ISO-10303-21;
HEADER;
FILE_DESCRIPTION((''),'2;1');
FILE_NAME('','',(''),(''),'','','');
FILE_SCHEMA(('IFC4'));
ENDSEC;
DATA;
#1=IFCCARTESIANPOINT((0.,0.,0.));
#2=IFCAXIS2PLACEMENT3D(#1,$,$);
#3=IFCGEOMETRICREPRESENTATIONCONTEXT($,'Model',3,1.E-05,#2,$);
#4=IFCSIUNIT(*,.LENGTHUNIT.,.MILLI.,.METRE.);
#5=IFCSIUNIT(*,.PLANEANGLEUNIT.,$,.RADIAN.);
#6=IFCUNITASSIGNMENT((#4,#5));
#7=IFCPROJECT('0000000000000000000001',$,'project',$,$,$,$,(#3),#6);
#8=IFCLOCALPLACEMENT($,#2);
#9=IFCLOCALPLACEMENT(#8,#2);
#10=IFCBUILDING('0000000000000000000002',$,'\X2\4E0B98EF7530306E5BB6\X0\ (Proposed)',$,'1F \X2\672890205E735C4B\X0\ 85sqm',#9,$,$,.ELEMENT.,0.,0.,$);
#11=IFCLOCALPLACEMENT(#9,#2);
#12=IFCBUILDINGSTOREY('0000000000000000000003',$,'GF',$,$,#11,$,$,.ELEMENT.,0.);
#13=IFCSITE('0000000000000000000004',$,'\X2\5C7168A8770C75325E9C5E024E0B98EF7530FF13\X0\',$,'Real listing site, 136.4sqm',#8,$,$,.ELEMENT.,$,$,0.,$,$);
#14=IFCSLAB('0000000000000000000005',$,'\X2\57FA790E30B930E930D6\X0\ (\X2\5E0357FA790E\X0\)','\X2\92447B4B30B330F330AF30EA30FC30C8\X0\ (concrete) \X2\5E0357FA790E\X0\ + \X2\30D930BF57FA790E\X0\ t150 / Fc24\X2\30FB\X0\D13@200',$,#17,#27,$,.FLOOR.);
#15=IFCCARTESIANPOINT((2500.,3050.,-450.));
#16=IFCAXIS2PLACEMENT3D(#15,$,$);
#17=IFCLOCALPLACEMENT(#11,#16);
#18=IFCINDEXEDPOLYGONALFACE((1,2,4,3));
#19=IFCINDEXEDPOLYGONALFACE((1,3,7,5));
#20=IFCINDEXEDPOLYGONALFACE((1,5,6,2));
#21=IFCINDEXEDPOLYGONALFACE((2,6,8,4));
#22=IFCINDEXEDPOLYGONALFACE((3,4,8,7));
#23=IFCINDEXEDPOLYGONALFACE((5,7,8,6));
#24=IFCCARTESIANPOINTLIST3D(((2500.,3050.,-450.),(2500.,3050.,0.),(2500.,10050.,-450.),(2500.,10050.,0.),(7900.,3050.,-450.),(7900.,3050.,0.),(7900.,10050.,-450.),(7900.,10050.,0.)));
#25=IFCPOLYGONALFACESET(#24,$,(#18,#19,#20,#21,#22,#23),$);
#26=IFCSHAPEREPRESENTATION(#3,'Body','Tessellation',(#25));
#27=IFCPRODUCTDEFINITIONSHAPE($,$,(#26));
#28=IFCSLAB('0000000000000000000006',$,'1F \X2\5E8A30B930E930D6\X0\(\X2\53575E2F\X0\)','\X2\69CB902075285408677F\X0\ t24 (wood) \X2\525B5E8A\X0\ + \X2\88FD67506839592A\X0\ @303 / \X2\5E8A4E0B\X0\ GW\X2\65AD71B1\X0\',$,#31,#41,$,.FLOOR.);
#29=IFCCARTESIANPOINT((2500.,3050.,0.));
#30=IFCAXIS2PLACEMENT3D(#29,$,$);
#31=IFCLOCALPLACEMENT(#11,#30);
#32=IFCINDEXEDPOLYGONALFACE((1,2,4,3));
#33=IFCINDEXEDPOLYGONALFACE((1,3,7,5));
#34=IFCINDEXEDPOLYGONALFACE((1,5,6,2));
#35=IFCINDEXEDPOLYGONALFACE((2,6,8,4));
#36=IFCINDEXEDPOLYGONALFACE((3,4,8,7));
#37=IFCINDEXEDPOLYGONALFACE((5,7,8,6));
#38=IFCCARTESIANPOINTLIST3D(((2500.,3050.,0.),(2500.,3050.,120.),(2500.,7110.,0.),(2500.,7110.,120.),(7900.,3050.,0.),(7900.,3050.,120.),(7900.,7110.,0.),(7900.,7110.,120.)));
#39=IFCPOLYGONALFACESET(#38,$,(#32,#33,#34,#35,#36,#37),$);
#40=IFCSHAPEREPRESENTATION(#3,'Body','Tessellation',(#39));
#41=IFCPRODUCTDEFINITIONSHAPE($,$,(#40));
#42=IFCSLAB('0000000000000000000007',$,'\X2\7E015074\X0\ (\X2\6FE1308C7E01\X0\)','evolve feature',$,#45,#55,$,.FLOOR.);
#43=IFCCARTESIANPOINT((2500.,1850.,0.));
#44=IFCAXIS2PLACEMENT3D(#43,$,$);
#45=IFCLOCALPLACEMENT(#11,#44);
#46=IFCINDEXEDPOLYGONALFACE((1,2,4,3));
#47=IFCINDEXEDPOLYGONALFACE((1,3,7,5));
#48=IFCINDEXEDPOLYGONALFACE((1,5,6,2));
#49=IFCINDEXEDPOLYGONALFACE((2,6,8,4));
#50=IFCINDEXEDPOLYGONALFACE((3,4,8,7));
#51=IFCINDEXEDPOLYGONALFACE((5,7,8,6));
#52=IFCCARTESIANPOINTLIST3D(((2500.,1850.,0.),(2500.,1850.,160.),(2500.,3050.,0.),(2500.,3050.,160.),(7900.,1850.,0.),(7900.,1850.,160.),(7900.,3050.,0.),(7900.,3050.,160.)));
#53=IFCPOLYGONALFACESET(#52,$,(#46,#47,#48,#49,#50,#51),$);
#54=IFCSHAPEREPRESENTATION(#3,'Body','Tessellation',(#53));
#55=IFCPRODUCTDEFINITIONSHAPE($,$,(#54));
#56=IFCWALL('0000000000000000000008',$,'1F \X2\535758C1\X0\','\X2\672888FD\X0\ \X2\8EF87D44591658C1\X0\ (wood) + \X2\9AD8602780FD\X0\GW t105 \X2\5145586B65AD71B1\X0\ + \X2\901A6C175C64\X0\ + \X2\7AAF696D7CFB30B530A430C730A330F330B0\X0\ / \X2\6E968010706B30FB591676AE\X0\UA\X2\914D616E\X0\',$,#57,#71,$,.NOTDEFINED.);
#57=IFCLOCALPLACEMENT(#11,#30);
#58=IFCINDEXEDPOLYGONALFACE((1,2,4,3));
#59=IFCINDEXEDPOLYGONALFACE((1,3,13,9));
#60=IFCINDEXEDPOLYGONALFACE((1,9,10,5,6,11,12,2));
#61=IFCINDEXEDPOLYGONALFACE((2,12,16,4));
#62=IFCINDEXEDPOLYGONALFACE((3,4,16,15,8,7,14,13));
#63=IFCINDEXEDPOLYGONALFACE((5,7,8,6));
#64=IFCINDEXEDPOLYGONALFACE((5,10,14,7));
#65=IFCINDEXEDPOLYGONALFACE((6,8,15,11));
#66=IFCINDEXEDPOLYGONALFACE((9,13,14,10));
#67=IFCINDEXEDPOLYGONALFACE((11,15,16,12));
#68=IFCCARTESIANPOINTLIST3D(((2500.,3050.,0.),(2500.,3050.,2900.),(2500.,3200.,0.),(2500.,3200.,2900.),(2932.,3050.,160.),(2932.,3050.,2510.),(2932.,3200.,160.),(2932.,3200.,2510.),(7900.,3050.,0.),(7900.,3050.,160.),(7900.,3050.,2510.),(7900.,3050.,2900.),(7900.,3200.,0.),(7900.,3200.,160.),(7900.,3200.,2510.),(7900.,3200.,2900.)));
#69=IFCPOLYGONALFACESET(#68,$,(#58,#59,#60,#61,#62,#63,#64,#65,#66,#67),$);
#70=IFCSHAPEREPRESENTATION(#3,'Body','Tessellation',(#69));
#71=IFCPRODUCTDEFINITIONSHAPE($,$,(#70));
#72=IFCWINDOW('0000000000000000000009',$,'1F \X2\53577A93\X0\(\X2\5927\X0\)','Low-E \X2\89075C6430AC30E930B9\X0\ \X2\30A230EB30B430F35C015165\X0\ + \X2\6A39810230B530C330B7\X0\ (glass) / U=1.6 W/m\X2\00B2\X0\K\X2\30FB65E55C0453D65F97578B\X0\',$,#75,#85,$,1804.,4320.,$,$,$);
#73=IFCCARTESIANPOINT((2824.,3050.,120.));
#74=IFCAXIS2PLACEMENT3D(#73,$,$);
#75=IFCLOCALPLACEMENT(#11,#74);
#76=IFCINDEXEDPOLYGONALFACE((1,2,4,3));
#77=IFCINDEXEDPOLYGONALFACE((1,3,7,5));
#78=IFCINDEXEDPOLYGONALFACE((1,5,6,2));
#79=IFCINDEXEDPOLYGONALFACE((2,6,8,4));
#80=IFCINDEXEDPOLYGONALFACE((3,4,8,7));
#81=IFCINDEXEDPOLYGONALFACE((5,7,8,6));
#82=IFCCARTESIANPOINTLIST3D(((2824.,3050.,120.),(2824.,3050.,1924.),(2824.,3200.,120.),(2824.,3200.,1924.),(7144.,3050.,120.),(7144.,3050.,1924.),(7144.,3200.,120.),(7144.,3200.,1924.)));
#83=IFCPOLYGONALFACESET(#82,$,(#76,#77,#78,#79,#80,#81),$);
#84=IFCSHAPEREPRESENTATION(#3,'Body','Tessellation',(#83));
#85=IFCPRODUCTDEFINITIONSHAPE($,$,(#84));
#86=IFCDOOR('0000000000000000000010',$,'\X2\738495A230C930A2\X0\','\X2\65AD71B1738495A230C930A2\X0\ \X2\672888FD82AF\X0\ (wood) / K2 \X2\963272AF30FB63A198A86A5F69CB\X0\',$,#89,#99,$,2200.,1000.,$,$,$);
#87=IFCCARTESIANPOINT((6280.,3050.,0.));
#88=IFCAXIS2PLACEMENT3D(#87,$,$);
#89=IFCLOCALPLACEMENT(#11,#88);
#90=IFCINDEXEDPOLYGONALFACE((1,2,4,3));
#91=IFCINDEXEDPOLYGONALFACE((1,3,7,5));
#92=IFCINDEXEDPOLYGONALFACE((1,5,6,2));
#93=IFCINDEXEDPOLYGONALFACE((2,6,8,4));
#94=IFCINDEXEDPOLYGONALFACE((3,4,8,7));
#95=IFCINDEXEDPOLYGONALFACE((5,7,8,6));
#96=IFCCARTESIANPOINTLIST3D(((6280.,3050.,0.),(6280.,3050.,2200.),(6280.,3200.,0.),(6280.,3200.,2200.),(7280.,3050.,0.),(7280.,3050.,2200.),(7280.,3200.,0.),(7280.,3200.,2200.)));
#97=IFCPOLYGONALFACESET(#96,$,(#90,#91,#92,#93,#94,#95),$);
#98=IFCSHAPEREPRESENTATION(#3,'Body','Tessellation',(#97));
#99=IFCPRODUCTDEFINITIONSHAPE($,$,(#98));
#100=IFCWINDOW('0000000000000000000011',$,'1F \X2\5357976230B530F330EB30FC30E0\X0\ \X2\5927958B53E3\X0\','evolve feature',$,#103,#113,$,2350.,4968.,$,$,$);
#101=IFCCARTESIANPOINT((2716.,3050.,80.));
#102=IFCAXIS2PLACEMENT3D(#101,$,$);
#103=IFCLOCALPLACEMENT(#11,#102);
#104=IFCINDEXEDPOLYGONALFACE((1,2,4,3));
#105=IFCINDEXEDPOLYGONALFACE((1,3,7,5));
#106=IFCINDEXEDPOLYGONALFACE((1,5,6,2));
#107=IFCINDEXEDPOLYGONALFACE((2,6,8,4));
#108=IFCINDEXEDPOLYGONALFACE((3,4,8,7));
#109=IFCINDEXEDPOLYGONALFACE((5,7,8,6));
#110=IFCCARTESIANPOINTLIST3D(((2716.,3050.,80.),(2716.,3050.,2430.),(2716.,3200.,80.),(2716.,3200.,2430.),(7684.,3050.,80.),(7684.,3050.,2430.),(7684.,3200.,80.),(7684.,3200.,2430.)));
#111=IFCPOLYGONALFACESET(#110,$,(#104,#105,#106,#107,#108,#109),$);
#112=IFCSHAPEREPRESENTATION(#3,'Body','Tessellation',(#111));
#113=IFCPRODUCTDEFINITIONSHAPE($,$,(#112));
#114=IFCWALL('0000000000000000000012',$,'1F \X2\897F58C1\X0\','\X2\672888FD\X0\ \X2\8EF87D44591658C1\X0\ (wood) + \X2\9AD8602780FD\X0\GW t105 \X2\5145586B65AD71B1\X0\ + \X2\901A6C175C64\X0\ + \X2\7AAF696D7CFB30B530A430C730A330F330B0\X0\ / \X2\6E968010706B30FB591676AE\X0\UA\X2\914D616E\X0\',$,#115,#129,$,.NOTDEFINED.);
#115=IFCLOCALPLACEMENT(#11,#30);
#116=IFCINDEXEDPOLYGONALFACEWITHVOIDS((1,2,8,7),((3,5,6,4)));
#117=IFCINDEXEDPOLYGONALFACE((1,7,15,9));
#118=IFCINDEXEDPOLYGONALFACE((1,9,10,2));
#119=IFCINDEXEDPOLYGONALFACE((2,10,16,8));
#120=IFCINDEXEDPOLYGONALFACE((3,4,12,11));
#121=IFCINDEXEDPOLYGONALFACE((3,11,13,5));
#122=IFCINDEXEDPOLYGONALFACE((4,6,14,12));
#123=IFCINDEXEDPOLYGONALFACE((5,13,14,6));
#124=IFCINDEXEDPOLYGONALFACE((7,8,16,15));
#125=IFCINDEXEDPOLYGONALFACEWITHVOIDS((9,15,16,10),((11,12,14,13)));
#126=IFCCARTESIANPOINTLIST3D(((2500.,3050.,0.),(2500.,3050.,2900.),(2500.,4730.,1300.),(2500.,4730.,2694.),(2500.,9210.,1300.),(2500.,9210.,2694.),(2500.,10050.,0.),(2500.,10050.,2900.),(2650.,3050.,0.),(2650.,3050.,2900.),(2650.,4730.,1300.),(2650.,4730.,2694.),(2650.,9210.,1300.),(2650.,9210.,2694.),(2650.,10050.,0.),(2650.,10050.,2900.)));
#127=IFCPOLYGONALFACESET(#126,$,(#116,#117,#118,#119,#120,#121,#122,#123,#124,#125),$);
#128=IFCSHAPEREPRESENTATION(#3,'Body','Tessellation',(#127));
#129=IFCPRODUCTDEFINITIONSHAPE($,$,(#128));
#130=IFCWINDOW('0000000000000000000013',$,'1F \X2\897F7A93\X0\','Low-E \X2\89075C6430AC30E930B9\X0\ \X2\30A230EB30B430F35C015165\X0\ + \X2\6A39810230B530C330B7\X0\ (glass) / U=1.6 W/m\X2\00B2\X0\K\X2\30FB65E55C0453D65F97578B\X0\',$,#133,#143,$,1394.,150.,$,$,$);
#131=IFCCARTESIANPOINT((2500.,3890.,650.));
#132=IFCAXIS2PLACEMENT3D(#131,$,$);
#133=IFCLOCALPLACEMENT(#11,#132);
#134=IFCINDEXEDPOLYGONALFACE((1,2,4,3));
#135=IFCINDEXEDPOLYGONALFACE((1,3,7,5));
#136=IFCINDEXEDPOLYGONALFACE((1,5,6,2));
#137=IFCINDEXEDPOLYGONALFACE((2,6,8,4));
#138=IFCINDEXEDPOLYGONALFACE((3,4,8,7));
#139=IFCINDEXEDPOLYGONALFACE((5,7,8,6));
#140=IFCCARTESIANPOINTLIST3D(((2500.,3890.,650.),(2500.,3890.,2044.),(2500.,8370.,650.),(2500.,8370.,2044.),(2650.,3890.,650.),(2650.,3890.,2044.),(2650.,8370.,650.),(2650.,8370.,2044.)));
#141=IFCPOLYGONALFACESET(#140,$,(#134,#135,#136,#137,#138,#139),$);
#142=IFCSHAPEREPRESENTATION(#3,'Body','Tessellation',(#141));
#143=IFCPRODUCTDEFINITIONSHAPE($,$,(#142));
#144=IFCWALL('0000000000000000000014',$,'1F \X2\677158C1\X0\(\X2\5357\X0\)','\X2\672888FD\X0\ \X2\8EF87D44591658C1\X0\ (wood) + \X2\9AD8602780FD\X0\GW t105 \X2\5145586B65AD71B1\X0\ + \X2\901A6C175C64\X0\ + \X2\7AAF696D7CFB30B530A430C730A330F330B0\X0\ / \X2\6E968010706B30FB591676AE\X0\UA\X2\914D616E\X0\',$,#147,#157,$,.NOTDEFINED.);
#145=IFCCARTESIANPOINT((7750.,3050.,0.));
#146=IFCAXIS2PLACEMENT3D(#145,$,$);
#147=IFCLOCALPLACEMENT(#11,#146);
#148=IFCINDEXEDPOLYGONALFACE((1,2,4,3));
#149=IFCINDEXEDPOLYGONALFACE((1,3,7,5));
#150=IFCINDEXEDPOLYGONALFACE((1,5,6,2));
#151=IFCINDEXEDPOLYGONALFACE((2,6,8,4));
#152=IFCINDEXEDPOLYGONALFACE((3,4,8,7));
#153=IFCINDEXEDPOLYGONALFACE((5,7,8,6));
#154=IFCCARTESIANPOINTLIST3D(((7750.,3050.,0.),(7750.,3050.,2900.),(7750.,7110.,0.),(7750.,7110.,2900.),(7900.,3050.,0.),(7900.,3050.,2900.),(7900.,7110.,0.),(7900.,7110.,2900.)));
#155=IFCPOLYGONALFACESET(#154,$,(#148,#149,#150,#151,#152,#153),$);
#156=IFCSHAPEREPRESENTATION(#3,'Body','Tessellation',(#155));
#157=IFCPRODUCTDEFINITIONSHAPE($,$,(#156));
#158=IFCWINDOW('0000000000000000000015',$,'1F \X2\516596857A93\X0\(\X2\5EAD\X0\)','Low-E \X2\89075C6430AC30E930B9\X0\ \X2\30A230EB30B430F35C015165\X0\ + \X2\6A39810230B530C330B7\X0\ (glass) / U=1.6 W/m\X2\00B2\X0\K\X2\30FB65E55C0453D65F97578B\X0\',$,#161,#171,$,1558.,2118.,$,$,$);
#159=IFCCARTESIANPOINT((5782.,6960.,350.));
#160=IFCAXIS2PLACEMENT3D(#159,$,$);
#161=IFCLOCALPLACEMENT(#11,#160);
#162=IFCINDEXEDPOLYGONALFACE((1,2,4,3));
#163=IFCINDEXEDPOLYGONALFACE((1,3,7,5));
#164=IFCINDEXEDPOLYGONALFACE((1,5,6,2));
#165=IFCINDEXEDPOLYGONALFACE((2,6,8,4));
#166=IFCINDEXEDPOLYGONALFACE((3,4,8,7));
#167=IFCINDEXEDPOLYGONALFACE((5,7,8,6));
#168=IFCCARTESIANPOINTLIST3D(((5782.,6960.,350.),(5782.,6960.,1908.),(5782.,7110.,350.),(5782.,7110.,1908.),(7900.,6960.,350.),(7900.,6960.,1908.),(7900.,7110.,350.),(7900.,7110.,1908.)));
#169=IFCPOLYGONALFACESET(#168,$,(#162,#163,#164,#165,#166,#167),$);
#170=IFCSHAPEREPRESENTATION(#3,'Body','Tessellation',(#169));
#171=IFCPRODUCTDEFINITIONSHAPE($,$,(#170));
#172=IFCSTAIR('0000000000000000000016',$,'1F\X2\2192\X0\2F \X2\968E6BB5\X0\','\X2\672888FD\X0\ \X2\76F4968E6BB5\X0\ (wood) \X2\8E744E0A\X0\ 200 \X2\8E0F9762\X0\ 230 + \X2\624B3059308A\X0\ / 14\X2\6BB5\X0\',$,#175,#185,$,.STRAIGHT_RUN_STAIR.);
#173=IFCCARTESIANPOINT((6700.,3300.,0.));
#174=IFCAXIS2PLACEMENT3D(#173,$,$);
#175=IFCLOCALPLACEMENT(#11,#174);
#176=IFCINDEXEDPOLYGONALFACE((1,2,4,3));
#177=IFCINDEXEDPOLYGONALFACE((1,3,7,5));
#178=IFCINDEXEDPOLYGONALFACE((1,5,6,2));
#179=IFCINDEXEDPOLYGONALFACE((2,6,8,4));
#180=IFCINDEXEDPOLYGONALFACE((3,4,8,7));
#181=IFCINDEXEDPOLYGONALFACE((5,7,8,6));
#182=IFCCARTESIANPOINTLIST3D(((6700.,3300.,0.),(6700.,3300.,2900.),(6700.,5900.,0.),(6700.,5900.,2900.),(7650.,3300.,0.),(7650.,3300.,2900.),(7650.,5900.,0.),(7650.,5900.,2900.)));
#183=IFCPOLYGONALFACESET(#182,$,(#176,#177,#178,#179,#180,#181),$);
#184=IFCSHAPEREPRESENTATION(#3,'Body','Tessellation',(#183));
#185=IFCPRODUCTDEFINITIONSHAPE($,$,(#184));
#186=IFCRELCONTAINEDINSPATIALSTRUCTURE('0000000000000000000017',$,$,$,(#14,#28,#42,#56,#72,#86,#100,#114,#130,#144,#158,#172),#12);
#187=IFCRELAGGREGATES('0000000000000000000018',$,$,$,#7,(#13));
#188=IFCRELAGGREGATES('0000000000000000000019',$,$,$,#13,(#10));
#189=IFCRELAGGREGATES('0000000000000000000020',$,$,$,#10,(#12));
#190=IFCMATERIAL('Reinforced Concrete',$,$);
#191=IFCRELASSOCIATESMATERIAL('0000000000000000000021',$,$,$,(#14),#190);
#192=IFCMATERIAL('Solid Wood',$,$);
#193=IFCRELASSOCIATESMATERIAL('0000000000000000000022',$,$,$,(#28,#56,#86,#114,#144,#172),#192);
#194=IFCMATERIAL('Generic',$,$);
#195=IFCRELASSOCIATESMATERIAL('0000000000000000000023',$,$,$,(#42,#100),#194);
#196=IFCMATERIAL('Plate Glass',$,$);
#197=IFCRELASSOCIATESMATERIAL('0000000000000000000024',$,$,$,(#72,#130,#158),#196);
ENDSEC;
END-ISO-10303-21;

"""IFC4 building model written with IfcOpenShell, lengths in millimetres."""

from ifc_helpers import new_model, si_unit, frame, frame_2d, origin, place, context, project, spatial, rectangle, extrude, material, element, fill, save


model = new_model("IFC4")

# Units and contexts
model_context = context("Model", 3, precision=1e-05, world=origin())
ifc_project = project(units=[si_unit("LENGTHUNIT", "METRE", prefix="MILLI"), si_unit("PLANEANGLEUNIT", "RADIAN")], contexts=[model_context])

# Site, building, storey
site_placement = place(None, origin())
site = spatial("IfcSite", under=ifc_project, at=site_placement, Name="山梨県甲府市下飯田３", ObjectType="Real listing site, 136.4sqm", CompositionType="ELEMENT", RefElevation=0.0)
building_placement = place(site_placement, origin())
building = spatial("IfcBuilding", under=site, at=building_placement, Name="下飯田の家 (Proposed)", ObjectType="1F 木造平屋 85sqm", CompositionType="ELEMENT", ElevationOfRefHeight=0.0, ElevationOfTerrain=0.0)
storey_placement = place(building_placement, origin())
storey = spatial("IfcBuildingStorey", under=building, at=storey_placement, Name="GF", CompositionType="ELEMENT", Elevation=0.0)

# Slabs
ifc_material_1 = material(Name="Reinforced Concrete")
slab_1_placement = place(storey_placement, frame((2500.0, 3050.0, -450.0)))
element("IfcSlab", 1, at=slab_1_placement, inside=storey, material=ifc_material_1, Name="基礎スラブ (布基礎)", Description="鉄筋コンクリート (concrete) 布基礎 + ベタ基礎 t150 / Fc24・D13@200", PredefinedType="FLOOR", context=model_context, shape_type="SweptSolid", body=[
    extrude(rectangle(XDim=5400.0, YDim=7000.0, at=frame_2d((2700.0, 3500.0))), frame((2500.0, 3050.0, -450.0)), (0.0, 0.0, 1.0), 450.0),
])
ifc_material_2 = material(Name="Solid Wood")
slab_2_placement = place(storey_placement, frame((2500.0, 3050.0, 0.0)))
element("IfcSlab", 2, at=slab_2_placement, inside=storey, material=ifc_material_2, Name="1F 床スラブ(南帯)", Description="構造用合板 t24 (wood) 剛床 + 製材根太 @303 / 床下 GW断熱", PredefinedType="FLOOR", context=model_context, shape_type="SweptSolid", body=[
    extrude(rectangle(XDim=5400.0, YDim=4060.0, at=frame_2d((2700.0, 2030.0))), frame((2500.0, 3050.0, 0.0)), (0.0, 0.0, 1.0), 120.0),
])
ifc_material_3 = material(Name="Generic")
slab_3_placement = place(storey_placement, frame((2500.0, 1850.0, 0.0)))
element("IfcSlab", 3, at=slab_3_placement, inside=storey, material=ifc_material_3, Name="縁側 (濡れ縁)", Description="evolve feature", PredefinedType="FLOOR", context=model_context, shape_type="SweptSolid", body=[
    extrude(rectangle(XDim=5400.0, YDim=1200.0, at=frame_2d((2700.0, 600.0))), frame((2500.0, 1850.0, 0.0)), (0.0, 0.0, 1.0), 160.0),
])

# Wall, openings, windows, door
wall_1_placement = place(storey_placement, frame((2500.0, 3050.0, 0.0)))
wall_1 = element("IfcWall", 4, at=wall_1_placement, inside=storey, material=ifc_material_2, Name="1F 南壁", Description="木製 軸組外壁 (wood) + 高性能GW t105 充填断熱 + 通気層 + 窯業系サイディング / 準耐火・外皮UA配慮", PredefinedType="NOTDEFINED", context=model_context, shape_type="SweptSolid", body=[
    extrude(rectangle(XDim=5400.0, YDim=150.0, at=frame_2d((2700.0, 75.0))), frame((2500.0, 3050.0, 0.0)), (0.0, 0.0, 1.0), 2900.0),
])
opening_1_placement = place(storey_placement, frame((2824.0, 3050.0, 120.0)))
opening_1 = element("IfcOpeningElement", 5, at=opening_1_placement, cuts=wall_1, PredefinedType="NOTDEFINED", context=model_context, shape_type="SweptSolid", body=[
    extrude(rectangle(XDim=4320.0, YDim=150.0, at=frame_2d((2160.0, 75.0))), frame((2824.0, 3050.0, 120.0)), (0.0, 0.0, 1.0), 1804.0),
])
opening_2_placement = place(storey_placement, frame((6280.0, 3050.0, 0.0)))
opening_2 = element("IfcOpeningElement", 6, at=opening_2_placement, cuts=wall_1, PredefinedType="NOTDEFINED", context=model_context, shape_type="SweptSolid", body=[
    extrude(rectangle(XDim=1000.0, YDim=150.0, at=frame_2d((500.0, 75.0))), frame((6280.0, 3050.0, 0.0)), (0.0, 0.0, 1.0), 2200.0),
])
opening_3_placement = place(storey_placement, frame((2716.0, 3050.0, 80.0)))
opening_3 = element("IfcOpeningElement", 7, at=opening_3_placement, cuts=wall_1, PredefinedType="NOTDEFINED", context=model_context, shape_type="SweptSolid", body=[
    extrude(rectangle(XDim=4968.0, YDim=150.0, at=frame_2d((2484.0, 75.0))), frame((2716.0, 3050.0, 80.0)), (0.0, 0.0, 1.0), 2350.0),
])
ifc_material_4 = material(Name="Plate Glass")
window_1_placement = place(storey_placement, frame((2824.0, 3050.0, 120.0)))
window_1 = element("IfcWindow", 8, at=window_1_placement, inside=storey, material=ifc_material_4, Name="1F 南窓(大)", Description="Low-E 複層ガラス アルゴン封入 + 樹脂サッシ (glass) / U=1.6 W/m²K・日射取得型", OverallHeight=1804.0, OverallWidth=4320.0, context=model_context, shape_type="SweptSolid", body=[
    extrude(rectangle(XDim=4320.0, YDim=150.0, at=frame_2d((2160.0, 75.0))), frame((2824.0, 3050.0, 120.0)), (0.0, 0.0, 1.0), 1804.0),
])
fill(opening_1, window_1)
door_1_placement = place(storey_placement, frame((6280.0, 3050.0, 0.0)))
door_1 = element("IfcDoor", 9, at=door_1_placement, inside=storey, material=ifc_material_2, Name="玄関ドア", Description="断熱玄関ドア 木製芯 (wood) / K2 防犯・採風機構", OverallHeight=2200.0, OverallWidth=1000.0, context=model_context, shape_type="SweptSolid", body=[
    extrude(rectangle(XDim=1000.0, YDim=150.0, at=frame_2d((500.0, 75.0))), frame((6280.0, 3050.0, 0.0)), (0.0, 0.0, 1.0), 2200.0),
])
fill(opening_2, door_1)
window_2_placement = place(storey_placement, frame((2716.0, 3050.0, 80.0)))
window_2 = element("IfcWindow", 10, at=window_2_placement, inside=storey, material=ifc_material_3, Name="1F 南面サンルーム 大開口", Description="evolve feature", OverallHeight=2350.0, OverallWidth=4968.0, context=model_context, shape_type="SweptSolid", body=[
    extrude(rectangle(XDim=4968.0, YDim=150.0, at=frame_2d((2484.0, 75.0))), frame((2716.0, 3050.0, 80.0)), (0.0, 0.0, 1.0), 2350.0),
])
fill(opening_3, window_2)

# Walls, openings, windows
wall_2_placement = place(storey_placement, frame((2500.0, 3050.0, 0.0)))
wall_2 = element("IfcWall", 11, at=wall_2_placement, inside=storey, material=ifc_material_2, Name="1F 西壁", Description="木製 軸組外壁 (wood) + 高性能GW t105 充填断熱 + 通気層 + 窯業系サイディング / 準耐火・外皮UA配慮", PredefinedType="NOTDEFINED", context=model_context, shape_type="SweptSolid", body=[
    extrude(rectangle(XDim=150.0, YDim=7000.0, at=frame_2d((75.0, 3500.0))), frame((2500.0, 3050.0, 0.0)), (0.0, 0.0, 1.0), 2900.0),
])
opening_4_placement = place(storey_placement, frame((2500.0, 3890.0, 650.0)))
opening_4 = element("IfcOpeningElement", 12, at=opening_4_placement, cuts=wall_2, PredefinedType="NOTDEFINED", context=model_context, shape_type="SweptSolid", body=[
    extrude(rectangle(XDim=150.0, YDim=4480.0, at=frame_2d((75.0, 2240.0))), frame((2500.0, 3890.0, 650.0)), (0.0, 0.0, 1.0), 1394.0),
])
window_3_placement = place(storey_placement, frame((2500.0, 3890.0, 650.0)))
window_3 = element("IfcWindow", 13, at=window_3_placement, inside=storey, material=ifc_material_4, Name="1F 西窓", Description="Low-E 複層ガラス アルゴン封入 + 樹脂サッシ (glass) / U=1.6 W/m²K・日射取得型", OverallHeight=1394.0, OverallWidth=150.0, context=model_context, shape_type="SweptSolid", body=[
    extrude(rectangle(XDim=150.0, YDim=4480.0, at=frame_2d((75.0, 2240.0))), frame((2500.0, 3890.0, 650.0)), (0.0, 0.0, 1.0), 1394.0),
])
fill(opening_4, window_3)
wall_3_placement = place(storey_placement, frame((7750.0, 3050.0, 0.0)))
wall_3 = element("IfcWall", 14, at=wall_3_placement, inside=storey, material=ifc_material_2, Name="1F 東壁(南)", Description="木製 軸組外壁 (wood) + 高性能GW t105 充填断熱 + 通気層 + 窯業系サイディング / 準耐火・外皮UA配慮", PredefinedType="NOTDEFINED", context=model_context, shape_type="SweptSolid", body=[
    extrude(rectangle(XDim=150.0, YDim=4060.0, at=frame_2d((75.0, 2030.0))), frame((7750.0, 3050.0, 0.0)), (0.0, 0.0, 1.0), 2900.0),
])
opening_5_placement = place(storey_placement, frame((5782.0, 6960.0, 350.0)))
opening_5 = element("IfcOpeningElement", 15, at=opening_5_placement, cuts=wall_3, PredefinedType="NOTDEFINED", context=model_context, shape_type="SweptSolid", body=[
    extrude(rectangle(XDim=2118.0, YDim=150.0, at=frame_2d((1059.0, 75.0))), frame((5782.0, 6960.0, 350.0)), (0.0, 0.0, 1.0), 1558.0),
])
window_4_placement = place(storey_placement, frame((5782.0, 6960.0, 350.0)))
window_4 = element("IfcWindow", 16, at=window_4_placement, inside=storey, material=ifc_material_4, Name="1F 入隅窓(庭)", Description="Low-E 複層ガラス アルゴン封入 + 樹脂サッシ (glass) / U=1.6 W/m²K・日射取得型", OverallHeight=1558.0, OverallWidth=2118.0, context=model_context, shape_type="SweptSolid", body=[
    extrude(rectangle(XDim=2118.0, YDim=150.0, at=frame_2d((1059.0, 75.0))), frame((5782.0, 6960.0, 350.0)), (0.0, 0.0, 1.0), 1558.0),
])
fill(opening_5, window_4)

# Stair
stair_placement = place(storey_placement, frame((6700.0, 3300.0, 0.0)))
element("IfcStair", 17, at=stair_placement, inside=storey, material=ifc_material_2, Name="1F→2F 階段", Description="木製 直階段 (wood) 蹴上 200 踏面 230 + 手すり / 14段", PredefinedType="STRAIGHT_RUN_STAIR", context=model_context, shape_type="SweptSolid", body=[
    extrude(rectangle(XDim=950.0, YDim=2600.0, at=frame_2d((475.0, 1300.0))), frame((6700.0, 3300.0, 0.0)), (0.0, 0.0, 1.0), 2900.0),
])

save(model, "model.ifc")
